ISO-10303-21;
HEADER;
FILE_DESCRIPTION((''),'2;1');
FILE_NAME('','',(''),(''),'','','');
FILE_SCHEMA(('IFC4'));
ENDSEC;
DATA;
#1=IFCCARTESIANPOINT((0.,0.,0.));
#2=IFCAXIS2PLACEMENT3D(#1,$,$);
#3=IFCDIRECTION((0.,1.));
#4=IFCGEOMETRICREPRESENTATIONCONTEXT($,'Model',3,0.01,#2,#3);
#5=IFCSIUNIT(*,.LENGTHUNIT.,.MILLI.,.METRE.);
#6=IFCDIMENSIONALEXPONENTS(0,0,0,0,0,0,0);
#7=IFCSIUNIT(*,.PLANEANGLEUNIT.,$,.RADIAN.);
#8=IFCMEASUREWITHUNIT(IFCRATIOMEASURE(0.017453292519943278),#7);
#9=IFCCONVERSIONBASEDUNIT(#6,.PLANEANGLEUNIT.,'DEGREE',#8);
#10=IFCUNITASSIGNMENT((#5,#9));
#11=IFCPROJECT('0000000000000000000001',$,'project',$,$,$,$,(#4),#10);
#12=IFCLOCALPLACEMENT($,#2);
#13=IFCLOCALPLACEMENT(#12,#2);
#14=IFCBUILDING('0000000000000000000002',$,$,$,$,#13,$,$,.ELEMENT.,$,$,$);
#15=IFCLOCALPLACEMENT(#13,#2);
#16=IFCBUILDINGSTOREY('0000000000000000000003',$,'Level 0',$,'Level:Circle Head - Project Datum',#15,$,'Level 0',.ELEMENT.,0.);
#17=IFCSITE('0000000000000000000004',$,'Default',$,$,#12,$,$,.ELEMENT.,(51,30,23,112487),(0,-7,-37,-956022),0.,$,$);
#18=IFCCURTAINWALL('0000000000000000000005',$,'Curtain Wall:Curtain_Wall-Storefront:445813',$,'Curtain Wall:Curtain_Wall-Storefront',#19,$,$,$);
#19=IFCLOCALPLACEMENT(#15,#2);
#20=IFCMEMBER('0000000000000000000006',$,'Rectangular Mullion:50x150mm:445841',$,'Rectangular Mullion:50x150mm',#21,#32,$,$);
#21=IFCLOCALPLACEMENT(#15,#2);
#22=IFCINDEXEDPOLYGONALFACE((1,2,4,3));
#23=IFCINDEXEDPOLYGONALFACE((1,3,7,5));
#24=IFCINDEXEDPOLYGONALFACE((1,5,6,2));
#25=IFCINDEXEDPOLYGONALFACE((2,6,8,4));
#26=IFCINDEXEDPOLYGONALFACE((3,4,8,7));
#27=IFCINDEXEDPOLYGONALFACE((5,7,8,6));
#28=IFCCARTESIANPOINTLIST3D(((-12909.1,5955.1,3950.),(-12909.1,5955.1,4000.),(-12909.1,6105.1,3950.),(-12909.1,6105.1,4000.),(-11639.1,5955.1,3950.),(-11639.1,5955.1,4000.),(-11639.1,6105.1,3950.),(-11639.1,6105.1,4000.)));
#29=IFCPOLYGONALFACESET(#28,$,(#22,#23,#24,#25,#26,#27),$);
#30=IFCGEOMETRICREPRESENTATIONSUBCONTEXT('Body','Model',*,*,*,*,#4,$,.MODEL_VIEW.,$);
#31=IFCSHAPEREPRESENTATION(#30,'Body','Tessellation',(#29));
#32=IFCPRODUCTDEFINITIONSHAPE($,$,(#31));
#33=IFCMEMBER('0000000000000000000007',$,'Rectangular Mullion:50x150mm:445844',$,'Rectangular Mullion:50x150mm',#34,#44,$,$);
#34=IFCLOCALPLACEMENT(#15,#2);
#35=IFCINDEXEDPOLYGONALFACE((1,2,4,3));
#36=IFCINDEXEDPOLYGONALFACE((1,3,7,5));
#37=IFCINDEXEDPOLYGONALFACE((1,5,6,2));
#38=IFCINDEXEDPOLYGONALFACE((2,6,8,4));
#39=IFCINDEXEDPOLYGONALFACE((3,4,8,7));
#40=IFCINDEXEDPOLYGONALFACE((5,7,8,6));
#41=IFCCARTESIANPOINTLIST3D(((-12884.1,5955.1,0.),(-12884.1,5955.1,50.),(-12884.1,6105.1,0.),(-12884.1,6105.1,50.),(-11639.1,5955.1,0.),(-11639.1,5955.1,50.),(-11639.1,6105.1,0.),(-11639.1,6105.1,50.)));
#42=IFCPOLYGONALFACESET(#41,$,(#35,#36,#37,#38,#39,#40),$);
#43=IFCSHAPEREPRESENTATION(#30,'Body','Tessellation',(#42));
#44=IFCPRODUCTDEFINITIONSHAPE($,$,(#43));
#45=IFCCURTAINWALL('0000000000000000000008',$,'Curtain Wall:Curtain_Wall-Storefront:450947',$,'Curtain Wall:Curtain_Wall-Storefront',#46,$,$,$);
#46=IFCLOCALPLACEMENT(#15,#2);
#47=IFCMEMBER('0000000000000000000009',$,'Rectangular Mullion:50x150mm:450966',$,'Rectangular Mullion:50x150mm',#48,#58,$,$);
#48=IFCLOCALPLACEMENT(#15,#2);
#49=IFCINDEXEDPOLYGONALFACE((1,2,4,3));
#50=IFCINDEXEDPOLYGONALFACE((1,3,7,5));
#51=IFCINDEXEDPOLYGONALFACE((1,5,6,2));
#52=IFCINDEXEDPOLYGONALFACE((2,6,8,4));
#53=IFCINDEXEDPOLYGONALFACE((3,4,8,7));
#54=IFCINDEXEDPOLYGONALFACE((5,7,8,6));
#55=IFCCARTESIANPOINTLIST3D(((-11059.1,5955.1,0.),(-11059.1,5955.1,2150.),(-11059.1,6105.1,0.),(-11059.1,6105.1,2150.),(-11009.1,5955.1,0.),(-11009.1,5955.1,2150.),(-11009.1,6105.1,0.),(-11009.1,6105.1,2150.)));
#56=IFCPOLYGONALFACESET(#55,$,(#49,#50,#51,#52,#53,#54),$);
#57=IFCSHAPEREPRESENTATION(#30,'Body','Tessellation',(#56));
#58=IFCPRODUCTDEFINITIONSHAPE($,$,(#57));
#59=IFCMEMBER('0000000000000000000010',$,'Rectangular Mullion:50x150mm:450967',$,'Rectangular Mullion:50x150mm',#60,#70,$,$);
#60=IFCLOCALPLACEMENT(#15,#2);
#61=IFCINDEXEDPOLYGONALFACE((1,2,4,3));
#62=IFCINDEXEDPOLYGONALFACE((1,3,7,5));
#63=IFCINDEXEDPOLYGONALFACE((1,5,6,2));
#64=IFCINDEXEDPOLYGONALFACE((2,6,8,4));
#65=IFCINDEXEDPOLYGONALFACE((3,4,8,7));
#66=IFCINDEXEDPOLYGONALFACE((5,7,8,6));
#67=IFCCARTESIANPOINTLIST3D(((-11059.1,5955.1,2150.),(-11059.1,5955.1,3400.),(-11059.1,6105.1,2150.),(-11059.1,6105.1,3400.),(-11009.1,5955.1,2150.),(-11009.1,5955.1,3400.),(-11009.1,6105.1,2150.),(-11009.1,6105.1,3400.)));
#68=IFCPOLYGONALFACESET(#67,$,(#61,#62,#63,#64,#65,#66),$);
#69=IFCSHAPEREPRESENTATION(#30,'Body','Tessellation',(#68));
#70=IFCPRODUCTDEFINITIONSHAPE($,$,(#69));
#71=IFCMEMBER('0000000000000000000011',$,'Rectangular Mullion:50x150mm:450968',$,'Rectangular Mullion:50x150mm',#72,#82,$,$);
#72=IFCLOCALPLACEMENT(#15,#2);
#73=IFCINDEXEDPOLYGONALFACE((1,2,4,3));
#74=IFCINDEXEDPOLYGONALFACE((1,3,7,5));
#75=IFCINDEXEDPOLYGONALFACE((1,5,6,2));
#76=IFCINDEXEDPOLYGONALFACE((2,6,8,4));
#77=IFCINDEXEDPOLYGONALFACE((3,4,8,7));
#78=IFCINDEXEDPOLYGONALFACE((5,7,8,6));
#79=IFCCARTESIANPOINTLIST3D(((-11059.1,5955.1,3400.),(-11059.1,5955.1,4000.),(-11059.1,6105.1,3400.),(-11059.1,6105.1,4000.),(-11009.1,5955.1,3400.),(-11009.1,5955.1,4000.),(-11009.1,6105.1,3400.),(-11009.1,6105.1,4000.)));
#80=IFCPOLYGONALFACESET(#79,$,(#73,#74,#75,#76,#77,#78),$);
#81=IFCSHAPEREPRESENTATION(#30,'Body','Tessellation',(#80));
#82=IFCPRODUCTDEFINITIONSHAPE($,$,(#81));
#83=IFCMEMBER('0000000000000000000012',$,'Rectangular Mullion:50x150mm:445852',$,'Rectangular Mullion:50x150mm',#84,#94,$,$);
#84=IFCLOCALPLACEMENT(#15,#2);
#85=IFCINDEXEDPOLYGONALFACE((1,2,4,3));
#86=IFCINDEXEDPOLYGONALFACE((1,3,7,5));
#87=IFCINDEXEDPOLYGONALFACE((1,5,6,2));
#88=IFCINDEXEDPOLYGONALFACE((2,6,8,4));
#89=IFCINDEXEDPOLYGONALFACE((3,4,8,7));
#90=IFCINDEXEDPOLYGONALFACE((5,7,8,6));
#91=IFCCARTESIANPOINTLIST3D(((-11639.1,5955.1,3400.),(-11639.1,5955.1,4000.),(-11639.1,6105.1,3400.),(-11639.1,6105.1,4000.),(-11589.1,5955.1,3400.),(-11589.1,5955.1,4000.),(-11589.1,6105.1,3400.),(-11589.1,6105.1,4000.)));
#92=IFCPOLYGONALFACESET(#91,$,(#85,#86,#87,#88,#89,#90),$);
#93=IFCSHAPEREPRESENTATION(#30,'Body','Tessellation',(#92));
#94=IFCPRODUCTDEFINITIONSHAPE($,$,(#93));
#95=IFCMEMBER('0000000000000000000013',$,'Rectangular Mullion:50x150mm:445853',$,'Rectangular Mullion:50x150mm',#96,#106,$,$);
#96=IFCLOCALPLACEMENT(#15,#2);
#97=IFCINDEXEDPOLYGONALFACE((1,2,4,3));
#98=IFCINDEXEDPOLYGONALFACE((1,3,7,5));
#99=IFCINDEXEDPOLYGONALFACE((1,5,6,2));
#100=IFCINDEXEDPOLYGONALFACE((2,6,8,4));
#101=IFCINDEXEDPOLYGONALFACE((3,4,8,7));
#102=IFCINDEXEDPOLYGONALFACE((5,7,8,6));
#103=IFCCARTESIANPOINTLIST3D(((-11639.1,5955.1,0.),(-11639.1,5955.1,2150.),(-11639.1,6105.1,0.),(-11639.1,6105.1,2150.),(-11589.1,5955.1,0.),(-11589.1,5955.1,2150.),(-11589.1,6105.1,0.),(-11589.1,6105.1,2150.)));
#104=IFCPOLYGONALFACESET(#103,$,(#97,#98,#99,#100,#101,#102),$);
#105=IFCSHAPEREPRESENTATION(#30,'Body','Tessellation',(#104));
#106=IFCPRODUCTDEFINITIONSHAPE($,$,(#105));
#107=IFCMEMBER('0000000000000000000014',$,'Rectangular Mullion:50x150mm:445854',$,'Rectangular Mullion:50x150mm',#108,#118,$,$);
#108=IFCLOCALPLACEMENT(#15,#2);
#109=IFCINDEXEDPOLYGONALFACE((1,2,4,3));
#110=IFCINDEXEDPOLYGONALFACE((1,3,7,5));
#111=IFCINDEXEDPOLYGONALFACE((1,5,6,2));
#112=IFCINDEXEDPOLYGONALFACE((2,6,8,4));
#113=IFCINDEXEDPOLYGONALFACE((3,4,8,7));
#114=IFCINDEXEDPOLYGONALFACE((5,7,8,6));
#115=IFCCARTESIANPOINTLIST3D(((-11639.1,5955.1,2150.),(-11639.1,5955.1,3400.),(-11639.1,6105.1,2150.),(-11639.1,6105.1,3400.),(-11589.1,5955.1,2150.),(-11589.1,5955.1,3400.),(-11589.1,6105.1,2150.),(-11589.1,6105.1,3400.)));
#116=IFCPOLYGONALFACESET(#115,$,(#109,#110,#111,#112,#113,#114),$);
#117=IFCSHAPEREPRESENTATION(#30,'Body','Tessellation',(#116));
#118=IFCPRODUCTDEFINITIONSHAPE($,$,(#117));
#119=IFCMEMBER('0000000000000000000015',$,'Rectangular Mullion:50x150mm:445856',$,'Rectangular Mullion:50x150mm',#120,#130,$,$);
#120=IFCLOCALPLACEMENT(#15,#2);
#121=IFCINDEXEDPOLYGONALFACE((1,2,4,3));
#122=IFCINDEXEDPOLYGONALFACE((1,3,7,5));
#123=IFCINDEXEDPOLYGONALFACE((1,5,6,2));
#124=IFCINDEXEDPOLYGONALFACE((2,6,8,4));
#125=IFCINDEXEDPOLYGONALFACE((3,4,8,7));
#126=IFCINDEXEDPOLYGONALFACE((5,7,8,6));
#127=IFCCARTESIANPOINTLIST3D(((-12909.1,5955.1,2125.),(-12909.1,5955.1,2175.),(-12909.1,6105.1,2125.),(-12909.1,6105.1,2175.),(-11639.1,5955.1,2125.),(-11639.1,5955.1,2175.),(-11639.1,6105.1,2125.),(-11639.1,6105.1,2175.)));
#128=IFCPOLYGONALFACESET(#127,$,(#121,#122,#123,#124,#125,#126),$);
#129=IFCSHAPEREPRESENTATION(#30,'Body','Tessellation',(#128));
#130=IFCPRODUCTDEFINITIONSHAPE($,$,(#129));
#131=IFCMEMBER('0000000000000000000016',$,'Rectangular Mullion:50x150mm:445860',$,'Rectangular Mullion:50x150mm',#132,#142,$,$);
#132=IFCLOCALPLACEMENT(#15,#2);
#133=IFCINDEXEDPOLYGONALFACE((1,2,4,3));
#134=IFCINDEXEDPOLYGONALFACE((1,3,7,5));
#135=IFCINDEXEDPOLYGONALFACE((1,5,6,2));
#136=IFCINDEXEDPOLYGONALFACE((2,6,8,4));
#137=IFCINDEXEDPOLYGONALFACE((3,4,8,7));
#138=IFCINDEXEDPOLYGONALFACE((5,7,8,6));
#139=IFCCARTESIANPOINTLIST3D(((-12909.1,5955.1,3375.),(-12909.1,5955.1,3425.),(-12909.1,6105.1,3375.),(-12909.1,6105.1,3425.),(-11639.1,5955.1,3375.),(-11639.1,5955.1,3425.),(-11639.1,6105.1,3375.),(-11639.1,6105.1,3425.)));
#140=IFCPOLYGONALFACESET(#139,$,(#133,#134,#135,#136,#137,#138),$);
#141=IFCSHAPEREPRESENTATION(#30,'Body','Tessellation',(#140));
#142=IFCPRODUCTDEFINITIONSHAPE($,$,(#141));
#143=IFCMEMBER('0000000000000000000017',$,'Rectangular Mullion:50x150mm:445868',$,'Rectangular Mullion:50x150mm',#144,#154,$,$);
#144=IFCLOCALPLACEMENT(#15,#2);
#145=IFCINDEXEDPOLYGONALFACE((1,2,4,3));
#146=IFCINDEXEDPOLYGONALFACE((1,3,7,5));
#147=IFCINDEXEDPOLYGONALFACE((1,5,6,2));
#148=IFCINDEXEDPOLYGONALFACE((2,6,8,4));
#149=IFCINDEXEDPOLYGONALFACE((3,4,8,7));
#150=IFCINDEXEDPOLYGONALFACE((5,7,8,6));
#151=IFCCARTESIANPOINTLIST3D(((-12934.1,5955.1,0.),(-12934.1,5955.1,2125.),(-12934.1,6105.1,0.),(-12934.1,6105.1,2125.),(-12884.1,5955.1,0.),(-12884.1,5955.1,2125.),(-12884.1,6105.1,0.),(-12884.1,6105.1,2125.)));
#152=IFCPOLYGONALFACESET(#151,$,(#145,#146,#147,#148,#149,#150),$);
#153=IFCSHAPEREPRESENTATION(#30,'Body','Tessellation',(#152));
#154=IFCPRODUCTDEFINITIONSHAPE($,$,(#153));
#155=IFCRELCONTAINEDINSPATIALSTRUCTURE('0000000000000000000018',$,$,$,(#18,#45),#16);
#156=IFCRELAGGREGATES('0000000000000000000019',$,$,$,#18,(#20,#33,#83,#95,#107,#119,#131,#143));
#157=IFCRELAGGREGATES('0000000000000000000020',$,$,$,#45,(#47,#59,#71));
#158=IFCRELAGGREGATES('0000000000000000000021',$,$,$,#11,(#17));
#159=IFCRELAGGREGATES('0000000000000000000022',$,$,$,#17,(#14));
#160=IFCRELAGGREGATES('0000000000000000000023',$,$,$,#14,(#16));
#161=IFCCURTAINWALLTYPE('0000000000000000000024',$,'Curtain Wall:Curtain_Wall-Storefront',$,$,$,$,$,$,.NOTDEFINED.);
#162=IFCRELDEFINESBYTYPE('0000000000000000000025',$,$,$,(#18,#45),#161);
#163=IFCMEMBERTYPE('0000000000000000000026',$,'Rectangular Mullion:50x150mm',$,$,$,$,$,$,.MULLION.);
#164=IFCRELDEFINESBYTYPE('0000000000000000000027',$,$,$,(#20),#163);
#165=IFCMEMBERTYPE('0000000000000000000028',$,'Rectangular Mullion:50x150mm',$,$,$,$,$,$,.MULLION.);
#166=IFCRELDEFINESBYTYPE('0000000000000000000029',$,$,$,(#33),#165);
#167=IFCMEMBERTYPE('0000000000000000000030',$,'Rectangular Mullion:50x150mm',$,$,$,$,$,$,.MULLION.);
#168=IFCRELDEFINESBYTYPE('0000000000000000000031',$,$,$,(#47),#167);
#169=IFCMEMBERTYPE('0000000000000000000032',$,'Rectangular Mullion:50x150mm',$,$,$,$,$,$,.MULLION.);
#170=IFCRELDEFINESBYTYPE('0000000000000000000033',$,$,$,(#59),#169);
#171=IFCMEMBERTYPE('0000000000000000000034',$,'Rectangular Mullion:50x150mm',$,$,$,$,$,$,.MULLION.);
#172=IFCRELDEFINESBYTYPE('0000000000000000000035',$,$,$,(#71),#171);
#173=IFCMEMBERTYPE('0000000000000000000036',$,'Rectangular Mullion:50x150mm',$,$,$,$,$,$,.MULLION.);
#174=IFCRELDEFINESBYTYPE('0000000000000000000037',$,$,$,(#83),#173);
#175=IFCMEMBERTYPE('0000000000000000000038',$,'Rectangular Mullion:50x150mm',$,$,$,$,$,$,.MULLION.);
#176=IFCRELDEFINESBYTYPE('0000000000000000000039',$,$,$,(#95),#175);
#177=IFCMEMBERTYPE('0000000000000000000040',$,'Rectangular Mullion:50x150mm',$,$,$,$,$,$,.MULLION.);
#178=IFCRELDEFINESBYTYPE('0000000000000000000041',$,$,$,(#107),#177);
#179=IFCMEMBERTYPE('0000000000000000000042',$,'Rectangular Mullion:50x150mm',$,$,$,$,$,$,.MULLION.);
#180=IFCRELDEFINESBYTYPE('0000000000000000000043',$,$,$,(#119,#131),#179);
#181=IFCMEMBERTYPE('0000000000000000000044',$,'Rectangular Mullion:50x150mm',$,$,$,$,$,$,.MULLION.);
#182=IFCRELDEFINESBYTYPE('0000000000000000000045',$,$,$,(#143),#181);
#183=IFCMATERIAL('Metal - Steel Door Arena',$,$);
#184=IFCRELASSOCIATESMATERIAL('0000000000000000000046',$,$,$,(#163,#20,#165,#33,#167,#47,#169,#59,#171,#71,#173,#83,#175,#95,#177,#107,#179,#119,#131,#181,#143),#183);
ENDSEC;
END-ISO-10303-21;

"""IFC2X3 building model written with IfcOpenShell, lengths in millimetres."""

from ifc_helpers import new_model, entity, si_unit, converted_unit, direction, frame, origin, origin_2d_with_axis, place, context, subcontext, project, spatial, rectangle, extrude, source, transform, mapped, material, type_object, type_shapes, element, aggregate, save


model = new_model("IFC2X3")

# Units and contexts
model_context = context("Model", 3, precision=0.01, world=origin(), true_north=direction((0.0, 1.0)))
body_context = subcontext(model_context, "Body", "Model", "MODEL_VIEW")
ifc_project = project(units=[si_unit("LENGTHUNIT", "METRE", prefix="MILLI"), converted_unit("PLANEANGLEUNIT", "DEGREE", entity("IfcRatioMeasure", 0.017453292519943278), si_unit("PLANEANGLEUNIT", "RADIAN"), dimensions=[0, 0, 0, 0, 0, 0, 0])], contexts=[model_context])

# Site, building, storey
site_placement = place(None, origin())
site = spatial("IfcSite", under=ifc_project, at=site_placement, Name="Default", CompositionType="ELEMENT", RefLatitude=(51, 30, 23, 112487), RefLongitude=(0, -7, -37, -956022), RefElevation=0.0)
building_placement = place(site_placement, origin())
building = spatial("IfcBuilding", under=site, at=building_placement, CompositionType="ELEMENT")
storey_placement = place(building_placement, origin())
storey = spatial("IfcBuildingStorey", under=building, at=storey_placement, Name="Level 0", ObjectType="Level:Circle Head - Project Datum", LongName="Level 0", CompositionType="ELEMENT", Elevation=0.0)

# Curtain walls, members
curtain_wall_type = type_object("IfcCurtainWallType", Name="Curtain Wall:Curtain_Wall-Storefront", PredefinedType="NOTDEFINED")
curtain_wall_1_placement = place(storey_placement, origin())
curtain_wall_1 = element("IfcCurtainWall", 1, at=curtain_wall_1_placement, inside=storey, type_object=curtain_wall_type, Name="Curtain Wall:Curtain_Wall-Storefront:445813", ObjectType="Curtain Wall:Curtain_Wall-Storefront")
ifc_material_1 = material(Name="Metal - Steel Door Arena")
member_type_1 = type_object("IfcMemberType", Name="Rectangular Mullion:50x150mm", PredefinedType="MULLION", material=ifc_material_1)
shared_shape_1 = source(origin(), body_context, "Body", "SweptSolid", [
    extrude(rectangle(XDim=150.0, YDim=50.0, at=origin_2d_with_axis()), frame((-25.0, 0.0, -1270.0), z_axis=(0.0, 0.0, 1.0), x_axis=(0.0, -1.0, 0.0)), (0.0, 0.0, 1.0), 1270.0),
])
type_shapes(member_type_1, [shared_shape_1])
member_1_placement = place(curtain_wall_1_placement, frame((-12909.1, 6030.1, 4000.0), z_axis=(-1.0, 0.0, 0.0), x_axis=(0.0, 0.0, 1.0)))
member_1 = element("IfcMember", 2, at=member_1_placement, type_object=member_type_1, material=ifc_material_1, Name="Rectangular Mullion:50x150mm:445841", ObjectType="Rectangular Mullion:50x150mm", context=body_context, shape_type="MappedRepresentation", body=[
    mapped(shared_shape_1, transform((0.0, 0.0, 0.0), scale=1.0)),
])
member_type_2 = type_object("IfcMemberType", Name="Rectangular Mullion:50x150mm", PredefinedType="MULLION", material=ifc_material_1)
shared_shape_2 = source(origin(), body_context, "Body", "SweptSolid", [
    extrude(rectangle(XDim=150.0, YDim=50.0, at=origin_2d_with_axis()), frame((-25.0, 0.0, -1245.0), z_axis=(0.0, 0.0, 1.0), x_axis=(0.0, -1.0, 0.0)), (0.0, 0.0, 1.0), 1245.0),
])
type_shapes(member_type_2, [shared_shape_2])
member_2_placement = place(curtain_wall_1_placement, frame((-11639.1, 6030.1, 0.0), z_axis=(1.0, 0.0, 0.0), x_axis=(0.0, 0.0, -1.0)))
member_2 = element("IfcMember", 3, at=member_2_placement, type_object=member_type_2, material=ifc_material_1, Name="Rectangular Mullion:50x150mm:445844", ObjectType="Rectangular Mullion:50x150mm", context=body_context, shape_type="MappedRepresentation", body=[
    mapped(shared_shape_2, transform((0.0, 0.0, 0.0), scale=1.0)),
])
curtain_wall_2_placement = place(storey_placement, origin())
curtain_wall_2 = element("IfcCurtainWall", 4, at=curtain_wall_2_placement, inside=storey, type_object=curtain_wall_type, Name="Curtain Wall:Curtain_Wall-Storefront:450947", ObjectType="Curtain Wall:Curtain_Wall-Storefront")
member_type_3 = type_object("IfcMemberType", Name="Rectangular Mullion:50x150mm", PredefinedType="MULLION", material=ifc_material_1)
shared_shape_3 = source(origin(), body_context, "Body", "SweptSolid", [
    extrude(rectangle(XDim=150.0, YDim=50.0, at=origin_2d_with_axis()), frame((-25.0, 0.0, -2150.0), z_axis=(0.0, 0.0, 1.0), x_axis=(0.0, -1.0, 0.0)), (0.0, 0.0, 1.0), 2150.0),
])
type_shapes(member_type_3, [shared_shape_3])
member_3_placement = place(curtain_wall_2_placement, frame((-11059.1, 6030.1, 0.0), z_axis=(0.0, 0.0, -1.0), x_axis=(-1.0, 0.0, 0.0)))
member_3 = element("IfcMember", 5, at=member_3_placement, type_object=member_type_3, material=ifc_material_1, Name="Rectangular Mullion:50x150mm:450966", ObjectType="Rectangular Mullion:50x150mm", context=body_context, shape_type="MappedRepresentation", body=[
    mapped(shared_shape_3, transform((0.0, 0.0, 0.0), scale=1.0)),
])
member_type_4 = type_object("IfcMemberType", Name="Rectangular Mullion:50x150mm", PredefinedType="MULLION", material=ifc_material_1)
shared_shape_4 = source(origin(), body_context, "Body", "SweptSolid", [
    extrude(rectangle(XDim=150.0, YDim=50.0, at=origin_2d_with_axis()), frame((-25.0, 0.0, -1250.0), z_axis=(0.0, 0.0, 1.0), x_axis=(0.0, -1.0, 0.0)), (0.0, 0.0, 1.0), 1250.0),
])
type_shapes(member_type_4, [shared_shape_4])
member_4_placement = place(curtain_wall_2_placement, frame((-11059.1, 6030.1, 2150.0), z_axis=(0.0, 0.0, -1.0), x_axis=(-1.0, 0.0, 0.0)))
member_4 = element("IfcMember", 6, at=member_4_placement, type_object=member_type_4, material=ifc_material_1, Name="Rectangular Mullion:50x150mm:450967", ObjectType="Rectangular Mullion:50x150mm", context=body_context, shape_type="MappedRepresentation", body=[
    mapped(shared_shape_4, transform((0.0, 0.0, 0.0), scale=1.0)),
])
member_type_5 = type_object("IfcMemberType", Name="Rectangular Mullion:50x150mm", PredefinedType="MULLION", material=ifc_material_1)
shared_shape_5 = source(origin(), body_context, "Body", "SweptSolid", [
    extrude(rectangle(XDim=150.0, YDim=50.0, at=origin_2d_with_axis()), frame((-25.0, 0.0, -600.0), z_axis=(0.0, 0.0, 1.0), x_axis=(0.0, -1.0, 0.0)), (0.0, 0.0, 1.0), 600.0),
])
type_shapes(member_type_5, [shared_shape_5])
member_5_placement = place(curtain_wall_2_placement, frame((-11059.1, 6030.1, 3400.0), z_axis=(0.0, 0.0, -1.0), x_axis=(-1.0, 0.0, 0.0)))
member_5 = element("IfcMember", 7, at=member_5_placement, type_object=member_type_5, material=ifc_material_1, Name="Rectangular Mullion:50x150mm:450968", ObjectType="Rectangular Mullion:50x150mm", context=body_context, shape_type="MappedRepresentation", body=[
    mapped(shared_shape_5, transform((0.0, 0.0, 0.0), scale=1.0)),
])

# Members
member_type_6 = type_object("IfcMemberType", Name="Rectangular Mullion:50x150mm", PredefinedType="MULLION", material=ifc_material_1)
shared_shape_6 = source(origin(), body_context, "Body", "SweptSolid", [
    extrude(rectangle(XDim=150.0, YDim=50.0, at=origin_2d_with_axis()), frame((-25.0, 0.0, -600.0), z_axis=(0.0, 0.0, 1.0), x_axis=(0.0, -1.0, 0.0)), (0.0, 0.0, 1.0), 600.0),
])
type_shapes(member_type_6, [shared_shape_6])
member_6_placement = place(curtain_wall_1_placement, frame((-11589.1, 6030.1, 4000.0)))
member_6 = element("IfcMember", 8, at=member_6_placement, type_object=member_type_6, material=ifc_material_1, Name="Rectangular Mullion:50x150mm:445852", ObjectType="Rectangular Mullion:50x150mm", context=body_context, shape_type="MappedRepresentation", body=[
    mapped(shared_shape_6, transform((0.0, 0.0, 0.0), scale=1.0)),
])
member_type_7 = type_object("IfcMemberType", Name="Rectangular Mullion:50x150mm", PredefinedType="MULLION", material=ifc_material_1)
shared_shape_7 = source(origin(), body_context, "Body", "SweptSolid", [
    extrude(rectangle(XDim=150.0, YDim=50.0, at=origin_2d_with_axis()), frame((-25.0, 0.0, -2150.0), z_axis=(0.0, 0.0, 1.0), x_axis=(0.0, -1.0, 0.0)), (0.0, 0.0, 1.0), 2150.0),
])
type_shapes(member_type_7, [shared_shape_7])
member_7_placement = place(curtain_wall_1_placement, frame((-11589.1, 6030.1, 2150.0)))
member_7 = element("IfcMember", 9, at=member_7_placement, type_object=member_type_7, material=ifc_material_1, Name="Rectangular Mullion:50x150mm:445853", ObjectType="Rectangular Mullion:50x150mm", context=body_context, shape_type="MappedRepresentation", body=[
    mapped(shared_shape_7, transform((0.0, 0.0, 0.0), scale=1.0)),
])
member_type_8 = type_object("IfcMemberType", Name="Rectangular Mullion:50x150mm", PredefinedType="MULLION", material=ifc_material_1)
shared_shape_8 = source(origin(), body_context, "Body", "SweptSolid", [
    extrude(rectangle(XDim=150.0, YDim=50.0, at=origin_2d_with_axis()), frame((-25.0, 0.0, -1250.0), z_axis=(0.0, 0.0, 1.0), x_axis=(0.0, -1.0, 0.0)), (0.0, 0.0, 1.0), 1250.0),
])
type_shapes(member_type_8, [shared_shape_8])
member_8_placement = place(curtain_wall_1_placement, frame((-11589.1, 6030.1, 3400.0)))
member_8 = element("IfcMember", 10, at=member_8_placement, type_object=member_type_8, material=ifc_material_1, Name="Rectangular Mullion:50x150mm:445854", ObjectType="Rectangular Mullion:50x150mm", context=body_context, shape_type="MappedRepresentation", body=[
    mapped(shared_shape_8, transform((0.0, 0.0, 0.0), scale=1.0)),
])
member_type_9 = type_object("IfcMemberType", Name="Rectangular Mullion:50x150mm", PredefinedType="MULLION", material=ifc_material_1)
shared_shape_9 = source(origin(), body_context, "Body", "SweptSolid", [
    extrude(rectangle(XDim=150.0, YDim=50.0, at=origin_2d_with_axis()), frame((0.0, 0.0, -1270.0), z_axis=(0.0, 0.0, 1.0), x_axis=(0.0, -1.0, 0.0)), (0.0, 0.0, 1.0), 1270.0),
])
type_shapes(member_type_9, [shared_shape_9])
member_9_placement = place(curtain_wall_1_placement, frame((-12909.1, 6030.1, 2150.0), z_axis=(-1.0, 0.0, 0.0), x_axis=(0.0, 0.0, 1.0)))
member_9 = element("IfcMember", 11, at=member_9_placement, type_object=member_type_9, material=ifc_material_1, Name="Rectangular Mullion:50x150mm:445856", ObjectType="Rectangular Mullion:50x150mm", context=body_context, shape_type="MappedRepresentation", body=[
    mapped(shared_shape_9, transform((0.0, 0.0, 0.0), scale=1.0)),
])
member_10_placement = place(curtain_wall_1_placement, frame((-12909.1, 6030.1, 3400.0), z_axis=(-1.0, 0.0, 0.0), x_axis=(0.0, 0.0, 1.0)))
member_10 = element("IfcMember", 12, at=member_10_placement, type_object=member_type_9, material=ifc_material_1, Name="Rectangular Mullion:50x150mm:445860", ObjectType="Rectangular Mullion:50x150mm", context=body_context, shape_type="MappedRepresentation", body=[
    mapped(shared_shape_9, transform((0.0, 0.0, 0.0), scale=1.0)),
])
member_type_10 = type_object("IfcMemberType", Name="Rectangular Mullion:50x150mm", PredefinedType="MULLION", material=ifc_material_1)
shared_shape_10 = source(origin(), body_context, "Body", "SweptSolid", [
    extrude(rectangle(XDim=150.0, YDim=50.0, at=origin_2d_with_axis()), frame((0.0, 0.0, -2125.0), z_axis=(0.0, 0.0, 1.0), x_axis=(0.0, -1.0, 0.0)), (0.0, 0.0, 1.0), 2125.0),
])
type_shapes(member_type_10, [shared_shape_10])
member_11_placement = place(curtain_wall_1_placement, frame((-12909.1, 6030.1, 0.0), z_axis=(0.0, 0.0, -1.0), x_axis=(-1.0, 0.0, 0.0)))
member_11 = element("IfcMember", 13, at=member_11_placement, type_object=member_type_10, material=ifc_material_1, Name="Rectangular Mullion:50x150mm:445868", ObjectType="Rectangular Mullion:50x150mm", context=body_context, shape_type="MappedRepresentation", body=[
    mapped(shared_shape_10, transform((0.0, 0.0, 0.0), scale=1.0)),
])

aggregate(curtain_wall_1, [member_1, member_2, member_6, member_7, member_8, member_9, member_10, member_11])
aggregate(curtain_wall_2, [member_3, member_4, member_5])

save(model, "model.ifc")
